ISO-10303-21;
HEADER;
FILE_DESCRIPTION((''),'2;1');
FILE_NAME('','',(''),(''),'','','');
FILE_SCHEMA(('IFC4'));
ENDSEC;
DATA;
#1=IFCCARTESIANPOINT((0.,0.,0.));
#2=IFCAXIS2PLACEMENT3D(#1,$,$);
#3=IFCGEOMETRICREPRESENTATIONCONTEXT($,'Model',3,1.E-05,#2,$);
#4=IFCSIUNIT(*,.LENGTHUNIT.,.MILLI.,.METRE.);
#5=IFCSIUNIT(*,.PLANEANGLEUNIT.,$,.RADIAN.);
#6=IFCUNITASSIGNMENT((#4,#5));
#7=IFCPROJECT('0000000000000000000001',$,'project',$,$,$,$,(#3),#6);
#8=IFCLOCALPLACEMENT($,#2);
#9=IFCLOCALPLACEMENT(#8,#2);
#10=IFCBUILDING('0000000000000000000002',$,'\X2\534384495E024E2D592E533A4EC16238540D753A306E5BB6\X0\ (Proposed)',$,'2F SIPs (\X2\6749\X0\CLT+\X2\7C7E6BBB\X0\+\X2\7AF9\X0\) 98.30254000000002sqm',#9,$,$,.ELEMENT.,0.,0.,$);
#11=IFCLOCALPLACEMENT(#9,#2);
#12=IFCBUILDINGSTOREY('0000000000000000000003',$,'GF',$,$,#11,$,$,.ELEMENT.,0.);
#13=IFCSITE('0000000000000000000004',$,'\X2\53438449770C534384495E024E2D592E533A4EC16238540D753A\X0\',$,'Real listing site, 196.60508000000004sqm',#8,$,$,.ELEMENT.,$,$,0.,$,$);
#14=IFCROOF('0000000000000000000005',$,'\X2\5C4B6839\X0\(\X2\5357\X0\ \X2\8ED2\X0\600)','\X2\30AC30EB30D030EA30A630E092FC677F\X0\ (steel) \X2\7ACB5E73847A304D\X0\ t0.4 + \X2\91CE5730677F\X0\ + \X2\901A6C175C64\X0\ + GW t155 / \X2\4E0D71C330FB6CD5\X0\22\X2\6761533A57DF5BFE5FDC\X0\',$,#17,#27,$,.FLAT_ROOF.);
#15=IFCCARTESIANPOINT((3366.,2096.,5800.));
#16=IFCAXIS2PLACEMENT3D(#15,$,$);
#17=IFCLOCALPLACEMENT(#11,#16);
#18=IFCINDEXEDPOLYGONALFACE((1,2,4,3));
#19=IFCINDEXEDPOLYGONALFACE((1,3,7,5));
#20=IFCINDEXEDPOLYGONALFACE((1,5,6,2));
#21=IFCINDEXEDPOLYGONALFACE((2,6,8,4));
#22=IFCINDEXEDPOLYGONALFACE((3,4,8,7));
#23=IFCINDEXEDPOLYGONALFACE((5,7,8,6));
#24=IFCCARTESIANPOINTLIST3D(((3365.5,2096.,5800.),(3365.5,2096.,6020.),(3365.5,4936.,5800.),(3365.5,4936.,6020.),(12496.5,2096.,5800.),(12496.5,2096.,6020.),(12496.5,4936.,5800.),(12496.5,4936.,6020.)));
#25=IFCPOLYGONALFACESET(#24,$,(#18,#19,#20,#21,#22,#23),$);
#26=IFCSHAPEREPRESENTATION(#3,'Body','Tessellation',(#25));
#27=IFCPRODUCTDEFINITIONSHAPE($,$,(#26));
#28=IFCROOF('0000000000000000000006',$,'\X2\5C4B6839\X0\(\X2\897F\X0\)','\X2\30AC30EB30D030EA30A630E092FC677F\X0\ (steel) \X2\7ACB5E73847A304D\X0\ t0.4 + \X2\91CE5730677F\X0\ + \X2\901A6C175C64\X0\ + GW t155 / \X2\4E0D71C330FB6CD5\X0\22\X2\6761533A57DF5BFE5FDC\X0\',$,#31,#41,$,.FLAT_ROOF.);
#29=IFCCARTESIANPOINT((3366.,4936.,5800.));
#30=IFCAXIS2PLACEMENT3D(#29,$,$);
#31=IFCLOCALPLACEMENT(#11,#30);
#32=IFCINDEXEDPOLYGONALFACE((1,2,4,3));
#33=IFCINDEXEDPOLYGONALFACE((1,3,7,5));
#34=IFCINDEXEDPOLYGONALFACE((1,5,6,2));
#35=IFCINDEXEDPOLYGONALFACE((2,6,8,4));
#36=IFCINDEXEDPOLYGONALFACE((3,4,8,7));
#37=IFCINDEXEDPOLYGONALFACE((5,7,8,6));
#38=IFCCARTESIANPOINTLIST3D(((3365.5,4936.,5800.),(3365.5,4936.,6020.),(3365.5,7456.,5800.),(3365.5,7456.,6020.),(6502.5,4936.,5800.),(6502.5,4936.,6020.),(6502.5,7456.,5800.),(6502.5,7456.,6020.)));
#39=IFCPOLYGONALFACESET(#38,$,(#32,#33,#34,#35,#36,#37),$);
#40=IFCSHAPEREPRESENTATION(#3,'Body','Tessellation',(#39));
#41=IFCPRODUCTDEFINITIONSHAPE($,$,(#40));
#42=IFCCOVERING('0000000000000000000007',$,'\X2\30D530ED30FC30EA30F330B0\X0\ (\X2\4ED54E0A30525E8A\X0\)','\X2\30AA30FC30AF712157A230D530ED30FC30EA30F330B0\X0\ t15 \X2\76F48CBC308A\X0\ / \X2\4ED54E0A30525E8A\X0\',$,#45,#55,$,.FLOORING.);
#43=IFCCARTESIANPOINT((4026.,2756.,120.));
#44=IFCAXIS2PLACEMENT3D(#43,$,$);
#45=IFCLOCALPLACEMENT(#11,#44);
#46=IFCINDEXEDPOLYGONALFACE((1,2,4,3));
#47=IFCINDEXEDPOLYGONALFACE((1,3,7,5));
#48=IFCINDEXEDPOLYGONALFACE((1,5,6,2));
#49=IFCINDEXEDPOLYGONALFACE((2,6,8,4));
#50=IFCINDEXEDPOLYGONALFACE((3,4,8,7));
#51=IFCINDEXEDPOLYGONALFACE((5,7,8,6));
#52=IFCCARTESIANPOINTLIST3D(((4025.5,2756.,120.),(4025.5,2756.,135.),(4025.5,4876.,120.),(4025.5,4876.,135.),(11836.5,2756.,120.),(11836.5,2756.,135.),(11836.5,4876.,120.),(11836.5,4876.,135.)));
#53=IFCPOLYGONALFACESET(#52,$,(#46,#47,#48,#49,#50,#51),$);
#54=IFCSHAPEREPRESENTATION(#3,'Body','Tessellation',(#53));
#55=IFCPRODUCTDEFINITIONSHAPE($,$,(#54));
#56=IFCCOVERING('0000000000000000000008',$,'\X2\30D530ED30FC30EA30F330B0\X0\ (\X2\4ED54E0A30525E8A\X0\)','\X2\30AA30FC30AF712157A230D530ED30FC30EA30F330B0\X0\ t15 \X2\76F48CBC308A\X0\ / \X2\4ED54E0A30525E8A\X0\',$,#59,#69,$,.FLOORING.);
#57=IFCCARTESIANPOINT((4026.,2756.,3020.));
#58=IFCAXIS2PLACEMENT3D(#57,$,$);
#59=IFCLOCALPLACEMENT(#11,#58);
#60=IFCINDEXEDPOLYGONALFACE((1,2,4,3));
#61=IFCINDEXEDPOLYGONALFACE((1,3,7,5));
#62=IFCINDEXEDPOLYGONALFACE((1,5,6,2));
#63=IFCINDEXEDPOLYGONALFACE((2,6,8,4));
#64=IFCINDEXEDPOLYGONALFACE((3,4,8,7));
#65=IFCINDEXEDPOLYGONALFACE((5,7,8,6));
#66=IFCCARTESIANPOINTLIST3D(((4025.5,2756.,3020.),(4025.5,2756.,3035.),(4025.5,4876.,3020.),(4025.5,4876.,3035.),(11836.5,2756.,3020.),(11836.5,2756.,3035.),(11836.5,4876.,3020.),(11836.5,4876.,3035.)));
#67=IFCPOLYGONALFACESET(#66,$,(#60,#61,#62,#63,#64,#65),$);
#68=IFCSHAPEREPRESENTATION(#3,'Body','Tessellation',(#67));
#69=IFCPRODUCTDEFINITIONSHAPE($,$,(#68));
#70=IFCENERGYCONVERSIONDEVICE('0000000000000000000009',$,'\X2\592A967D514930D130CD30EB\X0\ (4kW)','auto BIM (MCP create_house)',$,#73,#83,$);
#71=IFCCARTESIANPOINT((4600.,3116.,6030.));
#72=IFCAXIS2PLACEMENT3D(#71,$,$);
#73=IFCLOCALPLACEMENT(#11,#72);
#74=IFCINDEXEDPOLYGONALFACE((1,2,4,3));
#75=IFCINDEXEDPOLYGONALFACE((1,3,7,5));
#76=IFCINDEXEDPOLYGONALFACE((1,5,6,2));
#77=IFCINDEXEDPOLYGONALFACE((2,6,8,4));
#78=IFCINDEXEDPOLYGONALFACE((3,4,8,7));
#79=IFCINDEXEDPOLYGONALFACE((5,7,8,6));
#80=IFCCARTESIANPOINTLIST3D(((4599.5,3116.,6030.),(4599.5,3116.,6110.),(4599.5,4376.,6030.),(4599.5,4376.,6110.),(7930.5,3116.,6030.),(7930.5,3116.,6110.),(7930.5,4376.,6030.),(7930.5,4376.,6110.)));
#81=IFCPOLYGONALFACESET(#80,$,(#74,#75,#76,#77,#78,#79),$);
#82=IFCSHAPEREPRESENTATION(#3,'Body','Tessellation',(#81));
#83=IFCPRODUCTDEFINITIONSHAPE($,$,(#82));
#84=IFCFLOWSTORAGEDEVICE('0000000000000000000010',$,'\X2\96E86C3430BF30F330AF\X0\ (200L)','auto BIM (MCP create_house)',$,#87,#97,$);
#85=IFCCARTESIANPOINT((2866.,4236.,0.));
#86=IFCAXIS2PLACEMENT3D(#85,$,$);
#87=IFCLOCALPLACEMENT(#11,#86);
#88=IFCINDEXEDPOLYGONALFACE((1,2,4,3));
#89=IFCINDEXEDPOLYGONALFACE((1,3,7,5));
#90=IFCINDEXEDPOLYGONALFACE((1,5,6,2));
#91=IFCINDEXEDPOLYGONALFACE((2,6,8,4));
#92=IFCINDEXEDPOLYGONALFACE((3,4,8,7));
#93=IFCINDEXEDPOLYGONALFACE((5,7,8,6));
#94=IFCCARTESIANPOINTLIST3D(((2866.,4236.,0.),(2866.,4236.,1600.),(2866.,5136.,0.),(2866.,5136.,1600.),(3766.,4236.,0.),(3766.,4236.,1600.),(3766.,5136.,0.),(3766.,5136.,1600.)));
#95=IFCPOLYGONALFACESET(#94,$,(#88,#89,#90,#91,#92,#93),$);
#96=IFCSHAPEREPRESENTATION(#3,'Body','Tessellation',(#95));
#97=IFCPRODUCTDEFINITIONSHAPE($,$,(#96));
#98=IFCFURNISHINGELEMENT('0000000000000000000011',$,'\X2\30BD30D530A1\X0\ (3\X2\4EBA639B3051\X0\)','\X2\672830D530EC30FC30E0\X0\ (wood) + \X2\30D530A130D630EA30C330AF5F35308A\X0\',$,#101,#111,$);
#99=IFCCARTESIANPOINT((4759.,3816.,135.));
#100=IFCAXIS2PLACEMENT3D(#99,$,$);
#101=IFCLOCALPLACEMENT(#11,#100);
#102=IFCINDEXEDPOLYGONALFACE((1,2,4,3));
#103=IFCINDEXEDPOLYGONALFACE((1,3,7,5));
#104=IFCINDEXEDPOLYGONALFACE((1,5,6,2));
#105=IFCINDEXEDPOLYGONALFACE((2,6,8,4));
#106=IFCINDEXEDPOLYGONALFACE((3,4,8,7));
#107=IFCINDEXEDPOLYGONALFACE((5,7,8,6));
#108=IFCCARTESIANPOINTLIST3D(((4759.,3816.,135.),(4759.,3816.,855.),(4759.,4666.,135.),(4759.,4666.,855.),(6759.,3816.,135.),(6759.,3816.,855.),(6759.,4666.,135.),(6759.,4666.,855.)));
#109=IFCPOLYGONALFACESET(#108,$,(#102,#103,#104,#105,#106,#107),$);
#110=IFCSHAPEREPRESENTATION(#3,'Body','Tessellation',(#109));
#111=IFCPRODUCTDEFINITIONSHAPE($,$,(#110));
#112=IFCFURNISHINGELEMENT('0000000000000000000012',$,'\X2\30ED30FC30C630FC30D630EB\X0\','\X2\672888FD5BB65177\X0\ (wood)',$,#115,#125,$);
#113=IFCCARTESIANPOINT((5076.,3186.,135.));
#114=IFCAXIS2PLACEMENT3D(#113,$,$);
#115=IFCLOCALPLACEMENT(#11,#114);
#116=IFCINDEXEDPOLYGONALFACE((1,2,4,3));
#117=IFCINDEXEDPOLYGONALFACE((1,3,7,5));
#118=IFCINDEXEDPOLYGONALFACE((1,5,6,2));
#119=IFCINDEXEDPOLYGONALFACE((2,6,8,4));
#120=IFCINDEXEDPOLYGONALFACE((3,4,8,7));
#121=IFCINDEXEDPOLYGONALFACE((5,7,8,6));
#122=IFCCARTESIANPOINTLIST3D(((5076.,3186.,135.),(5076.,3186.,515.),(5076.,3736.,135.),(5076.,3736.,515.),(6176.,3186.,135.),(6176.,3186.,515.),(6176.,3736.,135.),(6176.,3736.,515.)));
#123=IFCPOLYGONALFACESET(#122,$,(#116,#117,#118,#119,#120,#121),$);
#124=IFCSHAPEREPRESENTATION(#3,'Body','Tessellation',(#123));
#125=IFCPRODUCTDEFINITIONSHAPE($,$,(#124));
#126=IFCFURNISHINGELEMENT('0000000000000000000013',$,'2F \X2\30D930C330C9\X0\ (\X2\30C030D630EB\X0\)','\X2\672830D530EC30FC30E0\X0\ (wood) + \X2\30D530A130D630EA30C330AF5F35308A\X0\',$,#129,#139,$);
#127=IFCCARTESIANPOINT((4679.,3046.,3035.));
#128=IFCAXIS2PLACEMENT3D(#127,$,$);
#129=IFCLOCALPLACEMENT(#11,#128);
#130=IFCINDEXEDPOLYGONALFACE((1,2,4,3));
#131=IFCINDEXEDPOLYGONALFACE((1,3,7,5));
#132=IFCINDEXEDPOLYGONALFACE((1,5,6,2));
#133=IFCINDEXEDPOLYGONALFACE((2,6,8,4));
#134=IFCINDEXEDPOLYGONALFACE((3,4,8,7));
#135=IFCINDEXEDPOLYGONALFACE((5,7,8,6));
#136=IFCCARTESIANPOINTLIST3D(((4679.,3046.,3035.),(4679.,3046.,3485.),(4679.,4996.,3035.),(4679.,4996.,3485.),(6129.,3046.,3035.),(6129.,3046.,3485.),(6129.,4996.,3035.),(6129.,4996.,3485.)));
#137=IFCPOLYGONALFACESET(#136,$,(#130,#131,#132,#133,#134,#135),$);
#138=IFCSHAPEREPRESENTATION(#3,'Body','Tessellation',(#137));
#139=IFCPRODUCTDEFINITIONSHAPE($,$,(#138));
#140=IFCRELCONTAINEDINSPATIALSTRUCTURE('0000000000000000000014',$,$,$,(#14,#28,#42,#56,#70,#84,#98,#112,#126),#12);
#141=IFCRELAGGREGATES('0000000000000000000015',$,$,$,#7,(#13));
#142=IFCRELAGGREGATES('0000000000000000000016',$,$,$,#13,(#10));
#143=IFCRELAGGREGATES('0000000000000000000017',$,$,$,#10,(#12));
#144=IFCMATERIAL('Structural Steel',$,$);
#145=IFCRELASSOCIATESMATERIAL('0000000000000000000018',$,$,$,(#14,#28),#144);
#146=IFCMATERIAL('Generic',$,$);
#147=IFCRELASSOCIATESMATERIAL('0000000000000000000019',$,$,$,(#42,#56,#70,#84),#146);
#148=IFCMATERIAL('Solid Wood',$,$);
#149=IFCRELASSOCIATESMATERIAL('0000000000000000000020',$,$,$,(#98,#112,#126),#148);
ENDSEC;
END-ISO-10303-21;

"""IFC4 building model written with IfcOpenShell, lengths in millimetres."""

from ifc_helpers import new_model, si_unit, frame, frame_2d, origin, place, context, project, spatial, rectangle, extrude, material, element, save


model = new_model("IFC4")

# Units and contexts
model_context = context("Model", 3, precision=1e-05, world=origin())
ifc_project = project(units=[si_unit("LENGTHUNIT", "METRE", prefix="MILLI"), si_unit("PLANEANGLEUNIT", "RADIAN")], contexts=[model_context])

# Site, building, storey
site_placement = place(None, origin())
site = spatial("IfcSite", under=ifc_project, at=site_placement, Name="千葉県千葉市中央区仁戸名町", ObjectType="Real listing site, 196.60508000000004sqm", CompositionType="ELEMENT", RefElevation=0.0)
building_placement = place(site_placement, origin())
building = spatial("IfcBuilding", under=site, at=building_placement, Name="千葉市中央区仁戸名町の家 (Proposed)", ObjectType="2F SIPs (杉CLT+籾殻+竹) 98.30254000000002sqm", CompositionType="ELEMENT", ElevationOfRefHeight=0.0, ElevationOfTerrain=0.0)
storey_placement = place(building_placement, origin())
storey = spatial("IfcBuildingStorey", under=building, at=storey_placement, Name="GF", CompositionType="ELEMENT", Elevation=0.0)

# Shared definitions
ifc_material_1 = material(Name="Solid Wood")

# Roofs
ifc_material_2 = material(Name="Structural Steel")
roof_1_placement = place(storey_placement, frame((3366.0, 2096.0, 5800.0)))
element("IfcRoof", 1, at=roof_1_placement, inside=storey, material=ifc_material_2, Name="屋根(南 軒600)", Description="ガルバリウム鋼板 (steel) 立平葺き t0.4 + 野地板 + 通気層 + GW t155 / 不燃・法22条区域対応", PredefinedType="FLAT_ROOF", context=model_context, shape_type="SweptSolid", body=[
    extrude(rectangle(XDim=9131.0, YDim=2840.0, at=frame_2d((4565.0, 1420.0))), frame((3366.0, 2096.0, 5800.0)), (0.0, 0.0, 1.0), 220.0),
])
roof_2_placement = place(storey_placement, frame((3366.0, 4936.0, 5800.0)))
element("IfcRoof", 2, at=roof_2_placement, inside=storey, material=ifc_material_2, Name="屋根(西)", Description="ガルバリウム鋼板 (steel) 立平葺き t0.4 + 野地板 + 通気層 + GW t155 / 不燃・法22条区域対応", PredefinedType="FLAT_ROOF", context=model_context, shape_type="SweptSolid", body=[
    extrude(rectangle(XDim=3137.0, YDim=2520.0, at=frame_2d((1568.0, 1260.0))), frame((3366.0, 4936.0, 5800.0)), (0.0, 0.0, 1.0), 220.0),
])

# Coverings
ifc_material_3 = material(Name="Generic")
covering_1_placement = place(storey_placement, frame((4026.0, 2756.0, 120.0)))
element("IfcCovering", 3, at=covering_1_placement, inside=storey, material=ifc_material_3, Name="フローリング (仕上げ床)", Description="オーク無垢フローリング t15 直貼り / 仕上げ床", PredefinedType="FLOORING", context=model_context, shape_type="SweptSolid", body=[
    extrude(rectangle(XDim=7811.0, YDim=2120.0, at=frame_2d((3905.0, 1060.0))), frame((4026.0, 2756.0, 120.0)), (0.0, 0.0, 1.0), 15.0),
])
covering_2_placement = place(storey_placement, frame((4026.0, 2756.0, 3020.0)))
element("IfcCovering", 4, at=covering_2_placement, inside=storey, material=ifc_material_3, Name="フローリング (仕上げ床)", Description="オーク無垢フローリング t15 直貼り / 仕上げ床", PredefinedType="FLOORING", context=model_context, shape_type="SweptSolid", body=[
    extrude(rectangle(XDim=7811.0, YDim=2120.0, at=frame_2d((3905.0, 1060.0))), frame((4026.0, 2756.0, 3020.0)), (0.0, 0.0, 1.0), 15.0),
])

# Energy conversion device
energy_conversion_device_placement = place(storey_placement, frame((4600.0, 3116.0, 6030.0)))
element("IfcEnergyConversionDevice", 5, at=energy_conversion_device_placement, inside=storey, material=ifc_material_3, Name="太陽光パネル (4kW)", Description="auto BIM (MCP create_house)", context=model_context, shape_type="SweptSolid", body=[
    extrude(rectangle(XDim=3331.0, YDim=1260.0, at=frame_2d((1665.0, 630.0))), frame((4600.0, 3116.0, 6030.0)), (0.0, 0.0, 1.0), 80.0),
])

# Flow storage device
flow_storage_device_placement = place(storey_placement, frame((2866.0, 4236.0, 0.0)))
element("IfcFlowStorageDevice", 6, at=flow_storage_device_placement, inside=storey, material=ifc_material_3, Name="雨水タンク (200L)", Description="auto BIM (MCP create_house)", context=model_context, shape_type="SweptSolid", body=[
    extrude(rectangle(XDim=900.0, YDim=900.0, at=frame_2d((450.0, 450.0))), frame((2866.0, 4236.0, 0.0)), (0.0, 0.0, 1.0), 1600.0),
])

# Furnishing elements
furnishing_1_placement = place(storey_placement, frame((4759.0, 3816.0, 135.0)))
element("IfcFurnishingElement", 7, at=furnishing_1_placement, inside=storey, material=ifc_material_1, Name="ソファ (3人掛け)", Description="木フレーム (wood) + ファブリック張り", context=model_context, shape_type="SweptSolid", body=[
    extrude(rectangle(XDim=2000.0, YDim=850.0, at=frame_2d((1000.0, 425.0))), frame((4759.0, 3816.0, 135.0)), (0.0, 0.0, 1.0), 720.0),
])
furnishing_2_placement = place(storey_placement, frame((5076.0, 3186.0, 135.0)))
element("IfcFurnishingElement", 8, at=furnishing_2_placement, inside=storey, material=ifc_material_1, Name="ローテーブル", Description="木製家具 (wood)", context=model_context, shape_type="SweptSolid", body=[
    extrude(rectangle(XDim=1100.0, YDim=550.0, at=frame_2d((550.0, 275.0))), frame((5076.0, 3186.0, 135.0)), (0.0, 0.0, 1.0), 380.0),
])
furnishing_3_placement = place(storey_placement, frame((4679.0, 3046.0, 3035.0)))
element("IfcFurnishingElement", 9, at=furnishing_3_placement, inside=storey, material=ifc_material_1, Name="2F ベッド (ダブル)", Description="木フレーム (wood) + ファブリック張り", context=model_context, shape_type="SweptSolid", body=[
    extrude(rectangle(XDim=1450.0, YDim=1950.0, at=frame_2d((725.0, 975.0))), frame((4679.0, 3046.0, 3035.0)), (0.0, 0.0, 1.0), 450.0),
])

save(model, "model.ifc")
